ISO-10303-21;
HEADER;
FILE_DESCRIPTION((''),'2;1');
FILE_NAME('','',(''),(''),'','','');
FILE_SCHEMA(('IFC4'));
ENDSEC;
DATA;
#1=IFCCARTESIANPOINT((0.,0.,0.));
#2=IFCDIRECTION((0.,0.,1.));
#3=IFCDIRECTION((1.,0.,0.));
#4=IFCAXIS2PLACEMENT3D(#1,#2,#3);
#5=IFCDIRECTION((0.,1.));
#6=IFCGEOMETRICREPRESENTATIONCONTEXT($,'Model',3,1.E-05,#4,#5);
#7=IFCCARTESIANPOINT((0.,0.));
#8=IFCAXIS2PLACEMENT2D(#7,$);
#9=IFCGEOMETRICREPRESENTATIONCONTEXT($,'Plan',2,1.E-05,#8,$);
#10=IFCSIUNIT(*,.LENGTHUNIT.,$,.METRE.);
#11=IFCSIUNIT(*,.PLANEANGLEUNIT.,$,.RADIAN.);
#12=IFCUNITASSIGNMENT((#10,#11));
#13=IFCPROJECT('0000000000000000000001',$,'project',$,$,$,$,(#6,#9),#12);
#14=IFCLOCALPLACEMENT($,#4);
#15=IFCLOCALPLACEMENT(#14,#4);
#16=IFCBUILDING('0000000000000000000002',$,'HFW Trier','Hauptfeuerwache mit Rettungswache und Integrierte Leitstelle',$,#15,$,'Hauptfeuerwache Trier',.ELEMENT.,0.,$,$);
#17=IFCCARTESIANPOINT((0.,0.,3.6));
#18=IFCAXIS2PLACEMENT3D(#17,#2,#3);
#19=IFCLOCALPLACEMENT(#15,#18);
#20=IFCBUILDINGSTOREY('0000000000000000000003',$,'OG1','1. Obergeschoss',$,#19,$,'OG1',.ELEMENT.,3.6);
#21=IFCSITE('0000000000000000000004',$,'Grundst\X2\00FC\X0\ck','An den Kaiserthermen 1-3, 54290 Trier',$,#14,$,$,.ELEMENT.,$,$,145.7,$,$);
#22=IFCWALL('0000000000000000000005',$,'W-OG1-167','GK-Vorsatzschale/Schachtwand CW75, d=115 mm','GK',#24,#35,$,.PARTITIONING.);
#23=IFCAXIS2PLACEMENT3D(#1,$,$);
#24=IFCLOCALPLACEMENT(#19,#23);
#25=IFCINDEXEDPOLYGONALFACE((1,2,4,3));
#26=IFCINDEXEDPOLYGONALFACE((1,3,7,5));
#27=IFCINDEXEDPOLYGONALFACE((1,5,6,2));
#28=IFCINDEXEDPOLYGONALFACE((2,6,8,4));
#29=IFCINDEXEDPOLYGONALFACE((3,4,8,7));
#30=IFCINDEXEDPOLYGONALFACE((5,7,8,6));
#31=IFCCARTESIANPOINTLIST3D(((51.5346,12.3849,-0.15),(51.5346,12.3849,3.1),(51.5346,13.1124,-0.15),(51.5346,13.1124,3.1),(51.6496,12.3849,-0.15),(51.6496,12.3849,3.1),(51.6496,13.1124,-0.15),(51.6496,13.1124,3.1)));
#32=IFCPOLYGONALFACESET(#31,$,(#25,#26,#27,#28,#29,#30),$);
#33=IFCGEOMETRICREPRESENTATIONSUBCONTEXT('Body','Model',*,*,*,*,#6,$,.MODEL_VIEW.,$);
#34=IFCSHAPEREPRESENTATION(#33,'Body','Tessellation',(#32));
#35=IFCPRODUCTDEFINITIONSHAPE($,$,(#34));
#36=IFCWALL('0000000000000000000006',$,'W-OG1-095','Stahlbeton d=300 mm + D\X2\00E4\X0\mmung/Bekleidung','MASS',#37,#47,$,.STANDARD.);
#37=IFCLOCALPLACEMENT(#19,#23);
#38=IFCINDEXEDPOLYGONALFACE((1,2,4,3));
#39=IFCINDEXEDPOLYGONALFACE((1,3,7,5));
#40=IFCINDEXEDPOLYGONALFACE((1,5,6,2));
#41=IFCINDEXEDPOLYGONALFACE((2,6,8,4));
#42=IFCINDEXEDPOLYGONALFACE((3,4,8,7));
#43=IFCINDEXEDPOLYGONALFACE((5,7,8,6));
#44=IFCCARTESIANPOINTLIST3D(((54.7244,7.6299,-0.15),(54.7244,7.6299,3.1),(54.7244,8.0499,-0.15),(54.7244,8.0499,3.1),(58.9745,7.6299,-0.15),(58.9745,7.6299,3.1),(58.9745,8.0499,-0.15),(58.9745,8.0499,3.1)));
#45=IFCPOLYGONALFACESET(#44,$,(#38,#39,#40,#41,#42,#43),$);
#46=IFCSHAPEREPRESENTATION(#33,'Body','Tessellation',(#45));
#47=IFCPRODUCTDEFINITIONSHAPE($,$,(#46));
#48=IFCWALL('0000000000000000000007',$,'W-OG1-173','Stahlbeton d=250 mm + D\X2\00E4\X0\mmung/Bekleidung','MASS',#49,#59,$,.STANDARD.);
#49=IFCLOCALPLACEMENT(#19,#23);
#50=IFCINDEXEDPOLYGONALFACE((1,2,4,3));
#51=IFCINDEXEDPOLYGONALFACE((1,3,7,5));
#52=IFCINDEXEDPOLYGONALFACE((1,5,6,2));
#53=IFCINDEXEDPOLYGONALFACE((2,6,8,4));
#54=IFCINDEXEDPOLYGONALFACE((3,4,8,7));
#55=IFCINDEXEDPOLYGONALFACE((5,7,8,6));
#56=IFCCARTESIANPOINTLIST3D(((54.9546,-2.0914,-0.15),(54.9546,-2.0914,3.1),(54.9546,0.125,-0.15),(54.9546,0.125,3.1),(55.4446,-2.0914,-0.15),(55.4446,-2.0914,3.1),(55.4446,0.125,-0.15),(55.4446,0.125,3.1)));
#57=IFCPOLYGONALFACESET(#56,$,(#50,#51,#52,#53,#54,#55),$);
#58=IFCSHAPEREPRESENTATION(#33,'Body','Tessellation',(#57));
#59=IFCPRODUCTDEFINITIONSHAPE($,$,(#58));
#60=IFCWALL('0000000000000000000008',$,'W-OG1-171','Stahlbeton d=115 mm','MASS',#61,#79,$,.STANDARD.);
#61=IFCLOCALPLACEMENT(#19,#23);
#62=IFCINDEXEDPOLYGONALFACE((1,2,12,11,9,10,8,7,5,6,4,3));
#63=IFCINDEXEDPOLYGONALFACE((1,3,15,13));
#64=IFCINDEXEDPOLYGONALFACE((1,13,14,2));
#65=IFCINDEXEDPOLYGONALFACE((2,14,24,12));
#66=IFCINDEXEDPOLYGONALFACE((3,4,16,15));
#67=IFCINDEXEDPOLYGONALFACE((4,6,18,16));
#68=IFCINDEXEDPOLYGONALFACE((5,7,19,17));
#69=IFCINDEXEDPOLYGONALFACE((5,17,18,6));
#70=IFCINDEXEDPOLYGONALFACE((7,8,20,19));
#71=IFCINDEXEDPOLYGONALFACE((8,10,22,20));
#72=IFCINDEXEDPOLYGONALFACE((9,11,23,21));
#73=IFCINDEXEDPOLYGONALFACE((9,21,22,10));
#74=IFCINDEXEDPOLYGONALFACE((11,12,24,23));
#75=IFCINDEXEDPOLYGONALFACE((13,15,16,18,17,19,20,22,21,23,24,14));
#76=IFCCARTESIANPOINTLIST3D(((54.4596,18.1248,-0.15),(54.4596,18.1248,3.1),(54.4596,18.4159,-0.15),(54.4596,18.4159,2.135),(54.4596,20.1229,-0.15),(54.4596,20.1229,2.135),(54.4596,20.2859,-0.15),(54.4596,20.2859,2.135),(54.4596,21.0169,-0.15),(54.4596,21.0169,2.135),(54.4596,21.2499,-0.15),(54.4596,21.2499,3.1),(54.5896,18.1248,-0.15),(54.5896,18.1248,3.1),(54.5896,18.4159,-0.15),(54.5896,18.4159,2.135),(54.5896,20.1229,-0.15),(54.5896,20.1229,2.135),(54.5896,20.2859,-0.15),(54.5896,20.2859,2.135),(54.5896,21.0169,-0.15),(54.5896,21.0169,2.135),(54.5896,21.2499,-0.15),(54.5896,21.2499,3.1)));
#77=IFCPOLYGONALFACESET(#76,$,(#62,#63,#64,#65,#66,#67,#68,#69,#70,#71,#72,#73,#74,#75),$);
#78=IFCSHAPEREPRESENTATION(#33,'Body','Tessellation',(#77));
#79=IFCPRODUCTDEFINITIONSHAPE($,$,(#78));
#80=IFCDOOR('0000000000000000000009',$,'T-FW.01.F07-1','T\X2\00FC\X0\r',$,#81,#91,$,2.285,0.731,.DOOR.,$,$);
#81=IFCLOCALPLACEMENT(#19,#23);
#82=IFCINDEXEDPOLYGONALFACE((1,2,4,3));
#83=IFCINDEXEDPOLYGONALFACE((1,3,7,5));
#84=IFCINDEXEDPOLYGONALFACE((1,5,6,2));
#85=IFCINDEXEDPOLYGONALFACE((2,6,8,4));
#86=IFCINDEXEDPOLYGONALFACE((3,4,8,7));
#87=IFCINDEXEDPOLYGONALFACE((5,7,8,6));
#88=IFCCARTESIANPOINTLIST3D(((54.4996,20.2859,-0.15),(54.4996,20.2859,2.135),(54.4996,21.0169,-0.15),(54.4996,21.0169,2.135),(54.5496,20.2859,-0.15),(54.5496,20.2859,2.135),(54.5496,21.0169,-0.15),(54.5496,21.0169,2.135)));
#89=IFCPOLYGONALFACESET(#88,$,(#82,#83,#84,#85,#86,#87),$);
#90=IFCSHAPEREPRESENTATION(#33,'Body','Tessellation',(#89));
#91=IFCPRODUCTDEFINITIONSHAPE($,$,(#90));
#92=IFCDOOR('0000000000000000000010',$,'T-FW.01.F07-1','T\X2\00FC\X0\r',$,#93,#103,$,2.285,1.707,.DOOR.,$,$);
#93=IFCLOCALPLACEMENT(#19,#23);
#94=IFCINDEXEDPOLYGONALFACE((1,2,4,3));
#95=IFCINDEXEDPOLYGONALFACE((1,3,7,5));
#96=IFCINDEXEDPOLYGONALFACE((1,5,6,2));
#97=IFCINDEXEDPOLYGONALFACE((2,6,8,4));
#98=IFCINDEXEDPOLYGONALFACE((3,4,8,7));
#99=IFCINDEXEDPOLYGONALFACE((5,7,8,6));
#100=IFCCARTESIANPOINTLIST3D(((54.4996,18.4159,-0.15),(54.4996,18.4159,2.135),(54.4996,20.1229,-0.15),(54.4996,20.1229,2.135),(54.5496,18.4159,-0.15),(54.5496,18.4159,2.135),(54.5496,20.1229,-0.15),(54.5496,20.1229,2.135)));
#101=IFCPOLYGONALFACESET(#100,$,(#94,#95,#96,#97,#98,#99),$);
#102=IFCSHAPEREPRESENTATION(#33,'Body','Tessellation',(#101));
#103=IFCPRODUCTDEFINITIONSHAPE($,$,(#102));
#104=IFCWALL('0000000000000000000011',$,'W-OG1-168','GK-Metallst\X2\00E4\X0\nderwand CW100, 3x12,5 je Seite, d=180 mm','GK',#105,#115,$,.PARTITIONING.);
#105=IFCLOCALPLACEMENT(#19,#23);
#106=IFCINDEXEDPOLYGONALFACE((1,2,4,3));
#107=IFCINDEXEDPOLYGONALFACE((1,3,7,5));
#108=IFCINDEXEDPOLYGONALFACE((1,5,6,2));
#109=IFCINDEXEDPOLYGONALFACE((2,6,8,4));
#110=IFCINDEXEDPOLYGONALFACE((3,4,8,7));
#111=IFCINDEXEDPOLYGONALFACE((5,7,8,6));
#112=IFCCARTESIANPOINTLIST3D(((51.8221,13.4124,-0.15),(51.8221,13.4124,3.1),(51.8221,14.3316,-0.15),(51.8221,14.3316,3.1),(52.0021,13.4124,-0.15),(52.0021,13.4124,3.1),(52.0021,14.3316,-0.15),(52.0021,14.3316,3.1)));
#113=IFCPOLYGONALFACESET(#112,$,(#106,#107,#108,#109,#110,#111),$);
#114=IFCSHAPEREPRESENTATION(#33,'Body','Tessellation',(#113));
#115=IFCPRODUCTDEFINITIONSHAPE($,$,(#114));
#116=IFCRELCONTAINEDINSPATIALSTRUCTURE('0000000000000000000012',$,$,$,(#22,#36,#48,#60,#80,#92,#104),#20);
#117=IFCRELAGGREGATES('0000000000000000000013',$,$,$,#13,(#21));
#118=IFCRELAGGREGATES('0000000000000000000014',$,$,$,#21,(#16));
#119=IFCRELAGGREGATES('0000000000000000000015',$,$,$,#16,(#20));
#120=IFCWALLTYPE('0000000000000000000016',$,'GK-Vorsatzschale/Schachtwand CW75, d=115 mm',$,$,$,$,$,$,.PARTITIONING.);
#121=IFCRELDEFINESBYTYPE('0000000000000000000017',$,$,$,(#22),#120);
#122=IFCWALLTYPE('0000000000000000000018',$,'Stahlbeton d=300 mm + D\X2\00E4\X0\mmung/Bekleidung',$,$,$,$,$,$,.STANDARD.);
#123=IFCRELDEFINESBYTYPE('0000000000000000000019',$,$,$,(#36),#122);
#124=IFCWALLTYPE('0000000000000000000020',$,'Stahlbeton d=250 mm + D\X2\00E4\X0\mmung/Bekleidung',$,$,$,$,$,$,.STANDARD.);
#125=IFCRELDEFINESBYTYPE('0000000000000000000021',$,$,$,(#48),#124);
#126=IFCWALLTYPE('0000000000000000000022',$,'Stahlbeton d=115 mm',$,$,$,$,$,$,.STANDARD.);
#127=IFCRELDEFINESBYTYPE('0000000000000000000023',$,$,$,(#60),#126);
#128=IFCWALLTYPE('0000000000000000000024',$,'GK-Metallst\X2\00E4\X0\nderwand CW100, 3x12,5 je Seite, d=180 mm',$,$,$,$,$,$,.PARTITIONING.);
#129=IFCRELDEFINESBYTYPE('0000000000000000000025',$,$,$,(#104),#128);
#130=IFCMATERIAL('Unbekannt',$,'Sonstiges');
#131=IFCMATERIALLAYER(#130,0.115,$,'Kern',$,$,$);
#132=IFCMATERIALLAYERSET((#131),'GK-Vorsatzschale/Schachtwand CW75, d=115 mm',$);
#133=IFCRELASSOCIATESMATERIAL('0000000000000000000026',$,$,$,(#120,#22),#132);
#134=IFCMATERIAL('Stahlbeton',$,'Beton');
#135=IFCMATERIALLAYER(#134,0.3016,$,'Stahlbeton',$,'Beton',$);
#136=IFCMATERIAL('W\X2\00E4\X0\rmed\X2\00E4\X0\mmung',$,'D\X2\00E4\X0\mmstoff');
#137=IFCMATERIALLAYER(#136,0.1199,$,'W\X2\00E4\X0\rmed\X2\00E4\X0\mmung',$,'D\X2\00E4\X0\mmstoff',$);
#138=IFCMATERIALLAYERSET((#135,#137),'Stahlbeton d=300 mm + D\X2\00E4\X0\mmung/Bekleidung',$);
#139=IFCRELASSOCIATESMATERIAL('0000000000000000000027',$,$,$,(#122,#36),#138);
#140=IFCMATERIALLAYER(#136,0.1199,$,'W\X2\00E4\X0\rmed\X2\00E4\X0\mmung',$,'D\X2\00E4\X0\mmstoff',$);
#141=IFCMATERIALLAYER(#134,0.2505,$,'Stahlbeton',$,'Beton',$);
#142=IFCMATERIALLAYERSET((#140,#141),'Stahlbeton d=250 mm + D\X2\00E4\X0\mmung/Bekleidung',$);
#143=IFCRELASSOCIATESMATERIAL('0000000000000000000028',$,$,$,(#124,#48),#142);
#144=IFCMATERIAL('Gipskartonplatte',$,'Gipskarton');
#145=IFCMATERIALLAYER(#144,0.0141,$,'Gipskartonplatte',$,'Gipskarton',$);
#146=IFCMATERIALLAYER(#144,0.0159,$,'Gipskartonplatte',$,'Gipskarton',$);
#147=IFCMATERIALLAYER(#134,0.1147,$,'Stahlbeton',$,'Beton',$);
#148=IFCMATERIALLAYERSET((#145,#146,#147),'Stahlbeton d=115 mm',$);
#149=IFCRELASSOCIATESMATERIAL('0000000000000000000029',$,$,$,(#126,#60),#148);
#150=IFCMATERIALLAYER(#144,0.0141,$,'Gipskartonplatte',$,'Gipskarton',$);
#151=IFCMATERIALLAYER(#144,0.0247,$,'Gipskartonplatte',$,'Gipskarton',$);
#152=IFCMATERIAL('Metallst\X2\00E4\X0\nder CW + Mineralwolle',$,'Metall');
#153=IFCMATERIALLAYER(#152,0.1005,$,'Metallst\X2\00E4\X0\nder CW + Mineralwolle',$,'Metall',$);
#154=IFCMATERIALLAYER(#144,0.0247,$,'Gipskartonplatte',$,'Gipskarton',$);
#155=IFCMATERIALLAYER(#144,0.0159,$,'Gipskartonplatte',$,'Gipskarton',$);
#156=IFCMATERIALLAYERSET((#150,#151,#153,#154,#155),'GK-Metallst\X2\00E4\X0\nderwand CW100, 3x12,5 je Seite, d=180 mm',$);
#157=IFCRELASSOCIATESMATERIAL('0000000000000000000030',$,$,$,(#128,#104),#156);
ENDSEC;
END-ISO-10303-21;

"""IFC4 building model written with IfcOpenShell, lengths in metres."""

from ifc_helpers import new_model, si_unit, direction, frame, frame_2d, origin_with_axes, origin_2d, place, context, subcontext, project, spatial, rectangle, extrude, material, layer, layer_set, layer_usage, type_object, element, fill, save


model = new_model("IFC4")

# Units and contexts
model_context = context("Model", 3, precision=1e-05, world=origin_with_axes(), true_north=direction((0.0, 1.0)))
plan_context = context("Plan", 2, precision=1e-05, world=origin_2d())
body_context = subcontext(model_context, "Body", "Model", "MODEL_VIEW")
ifc_project = project(units=[si_unit("LENGTHUNIT", "METRE"), si_unit("PLANEANGLEUNIT", "RADIAN")], contexts=[model_context, plan_context])

# Site, building, storey
site_placement = place(None, origin_with_axes())
site = spatial("IfcSite", under=ifc_project, at=site_placement, Name="Grundstück", Description="An den Kaiserthermen 1-3, 54290 Trier", CompositionType="ELEMENT", RefElevation=145.7)
building_placement = place(site_placement, origin_with_axes())
building = spatial("IfcBuilding", under=site, at=building_placement, Name="HFW Trier", Description="Hauptfeuerwache mit Rettungswache und Integrierte Leitstelle", LongName="Hauptfeuerwache Trier", CompositionType="ELEMENT", ElevationOfRefHeight=0.0)
storey_placement = place(building_placement, frame((0.0, 0.0, 3.6), z_axis=(0.0, 0.0, 1.0), x_axis=(1.0, 0.0, 0.0)))
storey = spatial("IfcBuildingStorey", under=building, at=storey_placement, Name="OG1", Description="1. Obergeschoss", LongName="OG1", CompositionType="ELEMENT", Elevation=3.6)

# Shared definitions
ifc_material_1 = material(Name="Gipskartonplatte", Category="Gipskarton")
ifc_material_2 = material(Name="Metallständer CW + Mineralwolle", Category="Metall")

# Shared definitions
ifc_material_3 = material(Name="Stahlbeton", Category="Beton")

# Walls
ifc_material_4 = material(Name="Unbekannt", Category="Sonstiges")
ifc_layer_1 = layer(ifc_material_4, 0.115, Name="Kern")
ifc_layer_set_1 = layer_set([ifc_layer_1], Name="GK-Vorsatzschale/Schachtwand CW75, d=115 mm")
ifc_layer_usage_1 = layer_usage(ifc_layer_set_1, "AXIS2", "POSITIVE", -0.0575)
wall_type_1 = type_object("IfcWallType", Name="GK-Vorsatzschale/Schachtwand CW75, d=115 mm", PredefinedType="PARTITIONING", material=ifc_layer_set_1)
wall_1_placement = place(storey_placement, frame((51.5921, 13.1124, -0.15), z_axis=(0.0, 0.0, 1.0), x_axis=(0.0, -1.0, 0.0)))
element("IfcWall", 1, at=wall_1_placement, inside=storey, type_object=wall_type_1, material=ifc_layer_usage_1, Name="W-OG1-167", Description="GK-Vorsatzschale/Schachtwand CW75, d=115 mm", ObjectType="GK", PredefinedType="PARTITIONING", context=body_context, shape_type="SweptSolid", body=[
    extrude(rectangle(XDim=0.7275, YDim=0.115, at=frame_2d((0.3637, 0.0))), origin_with_axes(), (0.0, 0.0, 1.0), 3.25),
])
ifc_layer_2 = layer(ifc_material_3, 0.3016, Name="Stahlbeton", Category="Beton")
ifc_material_5 = material(Name="Wärmedämmung", Category="Dämmstoff")
ifc_layer_3 = layer(ifc_material_5, 0.1199, Name="Wärmedämmung", Category="Dämmstoff")
ifc_layer_set_2 = layer_set([ifc_layer_2, ifc_layer_3], Name="Stahlbeton d=300 mm + Dämmung/Bekleidung")
ifc_layer_usage_2 = layer_usage(ifc_layer_set_2, "AXIS2", "POSITIVE", -0.21)
wall_type_2 = type_object("IfcWallType", Name="Stahlbeton d=300 mm + Dämmung/Bekleidung", PredefinedType="STANDARD", material=ifc_layer_set_2)
wall_2_placement = place(storey_placement, frame((54.7244, 7.8399, -0.15), z_axis=(0.0, 0.0, 1.0), x_axis=(1.0, 0.0, 0.0)))
element("IfcWall", 2, at=wall_2_placement, inside=storey, type_object=wall_type_2, material=ifc_layer_usage_2, Name="W-OG1-095", Description="Stahlbeton d=300 mm + Dämmung/Bekleidung", ObjectType="MASS", PredefinedType="STANDARD", context=body_context, shape_type="SweptSolid", body=[
    extrude(rectangle(XDim=4.2501, YDim=0.42, at=frame_2d((2.125, 0.0))), origin_with_axes(), (0.0, 0.0, 1.0), 3.25),
])
ifc_layer_4 = layer(ifc_material_5, 0.1199, Name="Wärmedämmung", Category="Dämmstoff")
ifc_layer_5 = layer(ifc_material_3, 0.2505, Name="Stahlbeton", Category="Beton")
ifc_layer_set_3 = layer_set([ifc_layer_4, ifc_layer_5], Name="Stahlbeton d=250 mm + Dämmung/Bekleidung")
ifc_layer_usage_3 = layer_usage(ifc_layer_set_3, "AXIS2", "POSITIVE", -0.245)
wall_type_3 = type_object("IfcWallType", Name="Stahlbeton d=250 mm + Dämmung/Bekleidung", PredefinedType="STANDARD", material=ifc_layer_set_3)
wall_3_placement = place(storey_placement, frame((55.1996, 0.125, -0.15), z_axis=(0.0, 0.0, 1.0), x_axis=(0.0, -1.0, 0.0)))
element("IfcWall", 3, at=wall_3_placement, inside=storey, type_object=wall_type_3, material=ifc_layer_usage_3, Name="W-OG1-173", Description="Stahlbeton d=250 mm + Dämmung/Bekleidung", ObjectType="MASS", PredefinedType="STANDARD", context=body_context, shape_type="SweptSolid", body=[
    extrude(rectangle(XDim=2.2164, YDim=0.49, at=frame_2d((1.1082, 0.0))), origin_with_axes(), (0.0, 0.0, 1.0), 3.25),
])

# Wall, openings, doors
ifc_layer_6 = layer(ifc_material_1, 0.0141, Name="Gipskartonplatte", Category="Gipskarton")
ifc_layer_7 = layer(ifc_material_1, 0.0159, Name="Gipskartonplatte", Category="Gipskarton")
ifc_layer_8 = layer(ifc_material_3, 0.1147, Name="Stahlbeton", Category="Beton")
ifc_layer_set_4 = layer_set([ifc_layer_6, ifc_layer_7, ifc_layer_8], Name="Stahlbeton d=115 mm")
ifc_layer_usage_4 = layer_usage(ifc_layer_set_4, "AXIS2", "POSITIVE", -0.065)
wall_type_4 = type_object("IfcWallType", Name="Stahlbeton d=115 mm", PredefinedType="STANDARD", material=ifc_layer_set_4)
wall_4_placement = place(storey_placement, frame((54.5246, 21.2499, -0.15), z_axis=(0.0, 0.0, 1.0), x_axis=(0.0, -1.0, 0.0)))
wall_4 = element("IfcWall", 4, at=wall_4_placement, inside=storey, type_object=wall_type_4, material=ifc_layer_usage_4, Name="W-OG1-171", Description="Stahlbeton d=115 mm", ObjectType="MASS", PredefinedType="STANDARD", context=body_context, shape_type="SweptSolid", body=[
    extrude(rectangle(XDim=3.1251, YDim=0.13, at=frame_2d((1.5625, 0.0))), origin_with_axes(), (0.0, 0.0, 1.0), 3.25),
])
opening_1_placement = place(wall_4_placement, frame((0.233, 0.0, 0.0), z_axis=(0.0, 0.0, 1.0), x_axis=(1.0, 0.0, 0.0)))
opening_1 = element("IfcOpeningElement", 5, at=opening_1_placement, cuts=wall_4, PredefinedType="OPENING", context=body_context, shape_type="SweptSolid", body=[
    extrude(rectangle(XDim=0.731, YDim=0.23, at=frame_2d((0.3655, 0.0))), origin_with_axes(), (0.0, 0.0, 1.0), 2.285),
])
opening_2_placement = place(wall_4_placement, frame((1.127, 0.0, 0.0), z_axis=(0.0, 0.0, 1.0), x_axis=(1.0, 0.0, 0.0)))
opening_2 = element("IfcOpeningElement", 6, at=opening_2_placement, cuts=wall_4, PredefinedType="OPENING", context=body_context, shape_type="SweptSolid", body=[
    extrude(rectangle(XDim=1.707, YDim=0.23, at=frame_2d((0.8535, 0.0))), origin_with_axes(), (0.0, 0.0, 1.0), 2.285),
])
door_1_placement = place(wall_4_placement, frame((0.233, 0.0, 0.0), z_axis=(0.0, 0.0, 1.0), x_axis=(1.0, 0.0, 0.0)))
door_1 = element("IfcDoor", 7, at=door_1_placement, inside=storey, Name="T-FW.01.F07-1", Description="Tür", OverallHeight=2.285, OverallWidth=0.731, PredefinedType="DOOR", context=body_context, shape_type="SweptSolid", body=[
    extrude(rectangle(XDim=0.731, YDim=0.05, at=frame_2d((0.3655, 0.0))), origin_with_axes(), (0.0, 0.0, 1.0), 2.285),
])
fill(opening_1, door_1)
door_2_placement = place(wall_4_placement, frame((1.127, 0.0, 0.0), z_axis=(0.0, 0.0, 1.0), x_axis=(1.0, 0.0, 0.0)))
door_2 = element("IfcDoor", 8, at=door_2_placement, inside=storey, Name="T-FW.01.F07-1", Description="Tür", OverallHeight=2.285, OverallWidth=1.707, PredefinedType="DOOR", context=body_context, shape_type="SweptSolid", body=[
    extrude(rectangle(XDim=1.707, YDim=0.05, at=frame_2d((0.8535, 0.0))), origin_with_axes(), (0.0, 0.0, 1.0), 2.285),
])
fill(opening_2, door_2)

# Wall
ifc_layer_9 = layer(ifc_material_1, 0.0141, Name="Gipskartonplatte", Category="Gipskarton")
ifc_layer_10 = layer(ifc_material_1, 0.0247, Name="Gipskartonplatte", Category="Gipskarton")
ifc_layer_11 = layer(ifc_material_2, 0.1005, Name="Metallständer CW + Mineralwolle", Category="Metall")
ifc_layer_12 = layer(ifc_material_1, 0.0247, Name="Gipskartonplatte", Category="Gipskarton")
ifc_layer_13 = layer(ifc_material_1, 0.0159, Name="Gipskartonplatte", Category="Gipskarton")
ifc_layer_set_5 = layer_set([ifc_layer_9, ifc_layer_10, ifc_layer_11, ifc_layer_12, ifc_layer_13], Name="GK-Metallständerwand CW100, 3x12,5 je Seite, d=180 mm")
ifc_layer_usage_5 = layer_usage(ifc_layer_set_5, "AXIS2", "POSITIVE", -0.09)
wall_type_5 = type_object("IfcWallType", Name="GK-Metallständerwand CW100, 3x12,5 je Seite, d=180 mm", PredefinedType="PARTITIONING", material=ifc_layer_set_5)
wall_5_placement = place(storey_placement, frame((51.9121, 14.3316, -0.15), z_axis=(0.0, 0.0, 1.0), x_axis=(0.0, -1.0, 0.0)))
element("IfcWall", 9, at=wall_5_placement, inside=storey, type_object=wall_type_5, material=ifc_layer_usage_5, Name="W-OG1-168", Description="GK-Metallständerwand CW100, 3x12,5 je Seite, d=180 mm", ObjectType="GK", PredefinedType="PARTITIONING", context=body_context, shape_type="SweptSolid", body=[
    extrude(rectangle(XDim=0.9192, YDim=0.18, at=frame_2d((0.4596, 0.0))), origin_with_axes(), (0.0, 0.0, 1.0), 3.25),
])

save(model, "model.ifc")
